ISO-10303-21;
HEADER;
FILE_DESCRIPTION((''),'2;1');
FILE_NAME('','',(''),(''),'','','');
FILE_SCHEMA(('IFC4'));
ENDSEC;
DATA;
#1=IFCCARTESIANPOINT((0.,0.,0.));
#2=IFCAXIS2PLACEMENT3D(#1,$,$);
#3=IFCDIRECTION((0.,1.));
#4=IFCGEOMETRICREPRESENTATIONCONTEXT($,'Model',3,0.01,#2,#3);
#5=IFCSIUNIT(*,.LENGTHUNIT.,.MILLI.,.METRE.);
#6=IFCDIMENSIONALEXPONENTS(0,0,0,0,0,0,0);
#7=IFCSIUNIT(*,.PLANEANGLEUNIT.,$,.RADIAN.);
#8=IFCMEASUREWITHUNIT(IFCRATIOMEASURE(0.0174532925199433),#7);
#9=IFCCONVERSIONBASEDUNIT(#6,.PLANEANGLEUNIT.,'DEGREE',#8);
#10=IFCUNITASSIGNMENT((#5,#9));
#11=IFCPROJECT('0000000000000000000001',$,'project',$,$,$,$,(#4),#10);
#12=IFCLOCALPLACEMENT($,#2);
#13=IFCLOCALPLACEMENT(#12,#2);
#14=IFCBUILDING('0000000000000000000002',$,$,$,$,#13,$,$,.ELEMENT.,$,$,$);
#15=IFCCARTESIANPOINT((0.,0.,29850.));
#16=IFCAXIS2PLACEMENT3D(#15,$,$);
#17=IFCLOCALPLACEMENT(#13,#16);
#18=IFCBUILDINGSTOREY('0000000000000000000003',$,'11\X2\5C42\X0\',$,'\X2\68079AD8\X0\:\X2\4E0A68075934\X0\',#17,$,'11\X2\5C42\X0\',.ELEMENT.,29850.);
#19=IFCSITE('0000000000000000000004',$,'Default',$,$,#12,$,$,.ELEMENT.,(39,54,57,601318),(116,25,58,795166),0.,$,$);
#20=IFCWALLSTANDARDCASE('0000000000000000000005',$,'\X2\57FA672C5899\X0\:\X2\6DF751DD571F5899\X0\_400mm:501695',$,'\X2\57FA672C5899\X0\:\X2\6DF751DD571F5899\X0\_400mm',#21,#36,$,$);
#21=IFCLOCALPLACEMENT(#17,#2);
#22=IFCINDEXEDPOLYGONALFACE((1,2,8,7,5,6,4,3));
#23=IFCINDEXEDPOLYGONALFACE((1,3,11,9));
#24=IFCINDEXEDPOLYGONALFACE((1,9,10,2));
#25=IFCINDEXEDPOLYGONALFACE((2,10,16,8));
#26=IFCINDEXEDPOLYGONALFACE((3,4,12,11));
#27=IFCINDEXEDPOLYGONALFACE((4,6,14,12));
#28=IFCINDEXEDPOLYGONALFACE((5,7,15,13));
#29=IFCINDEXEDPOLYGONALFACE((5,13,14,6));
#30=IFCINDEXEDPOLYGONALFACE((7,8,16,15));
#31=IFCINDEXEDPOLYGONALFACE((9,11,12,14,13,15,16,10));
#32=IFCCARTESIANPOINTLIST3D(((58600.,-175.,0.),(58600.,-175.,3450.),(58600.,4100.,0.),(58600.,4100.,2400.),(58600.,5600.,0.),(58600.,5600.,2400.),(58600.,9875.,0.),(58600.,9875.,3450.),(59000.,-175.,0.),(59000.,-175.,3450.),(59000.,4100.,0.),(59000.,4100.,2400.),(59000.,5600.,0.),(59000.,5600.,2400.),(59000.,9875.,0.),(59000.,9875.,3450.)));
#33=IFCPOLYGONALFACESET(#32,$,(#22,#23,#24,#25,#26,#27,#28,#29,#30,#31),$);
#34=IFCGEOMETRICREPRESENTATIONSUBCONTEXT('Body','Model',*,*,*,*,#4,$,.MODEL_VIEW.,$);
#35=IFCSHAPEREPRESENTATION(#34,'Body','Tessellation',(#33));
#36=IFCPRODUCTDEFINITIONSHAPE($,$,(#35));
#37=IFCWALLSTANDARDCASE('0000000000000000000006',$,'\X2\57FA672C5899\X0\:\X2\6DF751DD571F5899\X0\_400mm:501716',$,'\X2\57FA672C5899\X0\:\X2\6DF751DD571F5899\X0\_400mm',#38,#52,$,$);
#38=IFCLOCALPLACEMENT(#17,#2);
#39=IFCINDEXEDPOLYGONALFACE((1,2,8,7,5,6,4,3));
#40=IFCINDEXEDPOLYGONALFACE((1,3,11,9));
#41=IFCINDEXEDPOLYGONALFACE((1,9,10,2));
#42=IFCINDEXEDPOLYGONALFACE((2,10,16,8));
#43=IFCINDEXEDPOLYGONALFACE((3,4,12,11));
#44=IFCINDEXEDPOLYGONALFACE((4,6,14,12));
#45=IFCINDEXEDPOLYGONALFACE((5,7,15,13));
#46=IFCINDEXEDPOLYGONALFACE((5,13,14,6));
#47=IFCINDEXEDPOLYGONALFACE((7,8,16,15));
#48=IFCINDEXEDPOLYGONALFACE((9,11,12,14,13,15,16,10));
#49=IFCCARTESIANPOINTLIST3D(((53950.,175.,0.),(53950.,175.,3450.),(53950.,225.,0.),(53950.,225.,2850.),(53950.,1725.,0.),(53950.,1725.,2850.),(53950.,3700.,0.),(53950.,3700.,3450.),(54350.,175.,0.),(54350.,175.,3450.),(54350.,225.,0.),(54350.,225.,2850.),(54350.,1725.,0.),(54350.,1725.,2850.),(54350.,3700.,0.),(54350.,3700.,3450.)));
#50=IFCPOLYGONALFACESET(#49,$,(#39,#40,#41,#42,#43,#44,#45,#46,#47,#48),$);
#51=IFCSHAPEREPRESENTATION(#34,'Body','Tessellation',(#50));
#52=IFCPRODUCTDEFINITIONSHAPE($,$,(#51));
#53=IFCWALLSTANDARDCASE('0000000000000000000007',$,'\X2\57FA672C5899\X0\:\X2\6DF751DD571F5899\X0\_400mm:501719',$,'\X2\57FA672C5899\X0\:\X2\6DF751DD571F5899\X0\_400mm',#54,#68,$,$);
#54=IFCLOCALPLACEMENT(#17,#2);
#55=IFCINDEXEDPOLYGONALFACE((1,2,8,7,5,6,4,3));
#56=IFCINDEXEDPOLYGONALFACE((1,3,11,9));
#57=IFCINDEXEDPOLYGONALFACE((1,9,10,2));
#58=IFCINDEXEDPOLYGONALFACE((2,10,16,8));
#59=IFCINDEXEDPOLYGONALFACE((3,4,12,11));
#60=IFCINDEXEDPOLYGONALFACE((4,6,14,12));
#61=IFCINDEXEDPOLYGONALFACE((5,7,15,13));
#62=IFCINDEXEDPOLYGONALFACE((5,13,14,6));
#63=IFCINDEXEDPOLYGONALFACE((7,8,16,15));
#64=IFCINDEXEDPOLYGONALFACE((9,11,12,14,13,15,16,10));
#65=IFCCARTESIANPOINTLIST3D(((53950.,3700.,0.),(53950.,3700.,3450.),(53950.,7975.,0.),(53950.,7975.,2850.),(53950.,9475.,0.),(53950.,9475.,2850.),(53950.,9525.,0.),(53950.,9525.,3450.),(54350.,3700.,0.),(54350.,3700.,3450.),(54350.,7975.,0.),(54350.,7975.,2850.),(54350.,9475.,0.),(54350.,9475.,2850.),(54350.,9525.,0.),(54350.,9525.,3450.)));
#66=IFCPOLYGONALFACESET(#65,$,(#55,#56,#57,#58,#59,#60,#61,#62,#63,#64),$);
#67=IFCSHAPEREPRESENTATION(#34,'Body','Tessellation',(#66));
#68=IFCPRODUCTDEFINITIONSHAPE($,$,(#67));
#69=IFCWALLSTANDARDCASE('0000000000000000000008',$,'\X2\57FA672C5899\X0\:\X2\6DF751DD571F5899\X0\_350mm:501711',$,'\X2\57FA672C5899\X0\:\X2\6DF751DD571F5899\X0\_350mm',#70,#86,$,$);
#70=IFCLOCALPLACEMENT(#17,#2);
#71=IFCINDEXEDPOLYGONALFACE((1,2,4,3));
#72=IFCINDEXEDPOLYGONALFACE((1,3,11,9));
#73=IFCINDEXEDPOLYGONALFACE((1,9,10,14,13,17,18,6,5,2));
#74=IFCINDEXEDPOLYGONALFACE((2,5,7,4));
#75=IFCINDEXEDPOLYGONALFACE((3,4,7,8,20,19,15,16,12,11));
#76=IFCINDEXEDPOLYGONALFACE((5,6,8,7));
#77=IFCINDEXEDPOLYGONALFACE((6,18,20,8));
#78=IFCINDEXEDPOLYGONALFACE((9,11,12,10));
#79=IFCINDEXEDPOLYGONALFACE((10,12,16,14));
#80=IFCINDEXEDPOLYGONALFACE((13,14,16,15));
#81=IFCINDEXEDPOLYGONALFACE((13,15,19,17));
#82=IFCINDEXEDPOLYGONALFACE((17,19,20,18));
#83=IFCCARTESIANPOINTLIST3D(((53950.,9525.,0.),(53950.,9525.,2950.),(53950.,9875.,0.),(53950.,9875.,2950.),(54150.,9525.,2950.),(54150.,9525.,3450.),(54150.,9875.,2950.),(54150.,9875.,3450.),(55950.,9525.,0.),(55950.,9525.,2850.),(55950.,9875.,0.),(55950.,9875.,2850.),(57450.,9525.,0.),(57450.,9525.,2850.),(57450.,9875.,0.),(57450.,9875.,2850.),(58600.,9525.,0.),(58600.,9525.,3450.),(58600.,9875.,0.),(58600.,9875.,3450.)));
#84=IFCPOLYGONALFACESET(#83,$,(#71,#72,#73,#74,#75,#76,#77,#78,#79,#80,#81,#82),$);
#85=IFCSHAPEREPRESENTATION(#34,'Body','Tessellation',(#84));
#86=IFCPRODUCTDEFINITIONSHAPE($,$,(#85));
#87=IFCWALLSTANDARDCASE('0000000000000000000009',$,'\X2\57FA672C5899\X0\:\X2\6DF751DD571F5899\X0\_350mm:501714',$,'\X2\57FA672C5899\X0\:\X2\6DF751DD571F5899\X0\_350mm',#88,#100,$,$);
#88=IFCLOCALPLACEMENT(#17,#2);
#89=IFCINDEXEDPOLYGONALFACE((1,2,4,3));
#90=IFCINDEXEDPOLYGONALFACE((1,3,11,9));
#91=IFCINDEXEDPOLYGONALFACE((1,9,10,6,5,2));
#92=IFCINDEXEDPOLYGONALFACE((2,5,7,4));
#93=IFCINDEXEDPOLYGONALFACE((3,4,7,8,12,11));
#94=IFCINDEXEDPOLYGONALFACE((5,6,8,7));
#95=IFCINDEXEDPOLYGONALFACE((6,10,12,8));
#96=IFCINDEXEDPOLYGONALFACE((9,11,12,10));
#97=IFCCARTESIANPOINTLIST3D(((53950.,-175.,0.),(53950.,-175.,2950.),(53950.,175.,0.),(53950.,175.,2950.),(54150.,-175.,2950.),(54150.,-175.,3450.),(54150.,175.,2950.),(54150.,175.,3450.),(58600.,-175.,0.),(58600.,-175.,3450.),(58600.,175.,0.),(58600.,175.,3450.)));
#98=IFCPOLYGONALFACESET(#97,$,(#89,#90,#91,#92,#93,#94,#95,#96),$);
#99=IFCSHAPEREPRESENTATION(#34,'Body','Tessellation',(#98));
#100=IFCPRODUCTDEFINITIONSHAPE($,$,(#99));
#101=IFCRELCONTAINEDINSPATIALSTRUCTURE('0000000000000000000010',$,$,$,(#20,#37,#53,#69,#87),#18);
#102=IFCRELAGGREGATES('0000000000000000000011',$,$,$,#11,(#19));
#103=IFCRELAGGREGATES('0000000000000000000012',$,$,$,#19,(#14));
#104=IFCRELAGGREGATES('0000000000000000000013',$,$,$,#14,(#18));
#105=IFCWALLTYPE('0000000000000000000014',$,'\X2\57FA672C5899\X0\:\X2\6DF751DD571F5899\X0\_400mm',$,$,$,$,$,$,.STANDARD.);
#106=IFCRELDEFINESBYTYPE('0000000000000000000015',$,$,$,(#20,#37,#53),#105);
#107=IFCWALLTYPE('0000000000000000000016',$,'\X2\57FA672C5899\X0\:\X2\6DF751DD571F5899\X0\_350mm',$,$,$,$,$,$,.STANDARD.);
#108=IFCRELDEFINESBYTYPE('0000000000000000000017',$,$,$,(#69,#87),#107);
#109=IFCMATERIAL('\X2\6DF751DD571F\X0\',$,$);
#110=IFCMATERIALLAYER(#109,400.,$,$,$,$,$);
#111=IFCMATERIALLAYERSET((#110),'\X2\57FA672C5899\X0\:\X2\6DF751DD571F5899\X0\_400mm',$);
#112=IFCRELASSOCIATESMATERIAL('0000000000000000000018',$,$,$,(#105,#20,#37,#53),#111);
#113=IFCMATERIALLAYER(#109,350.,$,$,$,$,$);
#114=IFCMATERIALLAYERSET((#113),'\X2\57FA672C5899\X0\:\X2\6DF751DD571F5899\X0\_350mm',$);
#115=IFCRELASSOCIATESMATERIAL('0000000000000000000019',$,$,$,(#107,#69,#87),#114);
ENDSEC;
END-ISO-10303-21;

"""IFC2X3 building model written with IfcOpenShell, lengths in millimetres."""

from ifc_helpers import new_model, entity, si_unit, converted_unit, direction, frame, frame_2d, origin, origin_2d_with_axis, place, context, subcontext, project, spatial, polyline, rectangle, extrude, clip, bounded_halfspace, material, layer, layer_set, layer_usage, type_object, element, save


model = new_model("IFC2X3")

# Units and contexts
model_context = context("Model", 3, precision=0.01, world=origin(), true_north=direction((0.0, 1.0)))
body_context = subcontext(model_context, "Body", "Model", "MODEL_VIEW")
ifc_project = project(units=[si_unit("LENGTHUNIT", "METRE", prefix="MILLI"), converted_unit("PLANEANGLEUNIT", "DEGREE", entity("IfcRatioMeasure", 0.0174532925199433), si_unit("PLANEANGLEUNIT", "RADIAN"), dimensions=[0, 0, 0, 0, 0, 0, 0])], contexts=[model_context])

# Site, building, storey
site_placement = place(None, origin())
site = spatial("IfcSite", under=ifc_project, at=site_placement, Name="Default", CompositionType="ELEMENT", RefLatitude=(39, 54, 57, 601318), RefLongitude=(116, 25, 58, 795166), RefElevation=0.0)
building_placement = place(site_placement, origin())
building = spatial("IfcBuilding", under=site, at=building_placement, CompositionType="ELEMENT")
storey_placement = place(building_placement, frame((0.0, 0.0, 29850.0)))
storey = spatial("IfcBuildingStorey", under=building, at=storey_placement, Name="11层", ObjectType="标高:上标头", LongName="11层", CompositionType="ELEMENT", Elevation=29850.0)

# Walls, openings
ifc_material_1 = material(Name="混凝土")
ifc_layer_1 = layer(ifc_material_1, 400.0)
ifc_layer_set_1 = layer_set([ifc_layer_1], Name="基本墙:混凝土墙_400mm")
ifc_layer_usage_1 = layer_usage(ifc_layer_set_1, "AXIS2", "POSITIVE", -200.0)
wall_type_1 = type_object("IfcWallType", Name="基本墙:混凝土墙_400mm", PredefinedType="STANDARD", material=ifc_layer_set_1)
wall_1_placement = place(storey_placement, frame((58800.0, -175.0, 0.0), z_axis=(0.0, 0.0, 1.0), x_axis=(0.0, 1.0, 0.0)))
wall_1 = element("IfcWallStandardCase", 1, at=wall_1_placement, inside=storey, type_object=wall_type_1, material=ifc_layer_usage_1, Name="基本墙:混凝土墙_400mm:501695", ObjectType="基本墙:混凝土墙_400mm", context=body_context, shape_type="SweptSolid", body=[
    extrude(rectangle(XDim=10050.0, YDim=400.0, at=frame_2d((5025.0, 0.0), x_axis=(-1.0, 0.0))), origin(), (0.0, 0.0, 1.0), 3450.0),
])
opening_1_placement = place(wall_1_placement, origin())
element("IfcOpeningElement", 2, at=opening_1_placement, cuts=wall_1, ObjectType="Opening", context=body_context, shape_type="SweptSolid", body=[
    extrude(rectangle(XDim=2400.0, YDim=1500.0, at=frame_2d((0.0, 0.0), x_axis=(1.0, 0.0))), frame((5025.0, -200.0, 1200.0), z_axis=(0.0, 1.0, 0.0), x_axis=(0.0, 0.0, -1.0)), (0.0, 0.0, 1.0), 400.0),
])
ifc_layer_usage_2 = layer_usage(ifc_layer_set_1, "AXIS2", "POSITIVE", -200.0)
wall_2_placement = place(storey_placement, frame((54150.0, 175.0, 0.0), z_axis=(0.0, 0.0, 1.0), x_axis=(0.0, 1.0, 0.0)))
wall_2 = element("IfcWallStandardCase", 3, at=wall_2_placement, inside=storey, type_object=wall_type_1, material=ifc_layer_usage_2, Name="基本墙:混凝土墙_400mm:501716", ObjectType="基本墙:混凝土墙_400mm", context=body_context, shape_type="SweptSolid", body=[
    extrude(rectangle(XDim=3525.0, YDim=400.0, at=frame_2d((1762.5, 0.0), x_axis=(-1.0, 0.0))), origin(), (0.0, 0.0, 1.0), 3450.0),
])
opening_2_placement = place(wall_2_placement, origin())
element("IfcOpeningElement", 4, at=opening_2_placement, cuts=wall_2, ObjectType="Opening", context=body_context, shape_type="SweptSolid", body=[
    extrude(rectangle(XDim=2850.0, YDim=1500.0, at=origin_2d_with_axis()), frame((800.0, -200.0, 1425.0), z_axis=(0.0, 1.0, 0.0), x_axis=(0.0, 0.0, -1.0)), (0.0, 0.0, 1.0), 400.0),
])
ifc_layer_usage_3 = layer_usage(ifc_layer_set_1, "AXIS2", "POSITIVE", -200.0)
wall_3_placement = place(storey_placement, frame((54150.0, 3700.0, 0.0), z_axis=(0.0, 0.0, 1.0), x_axis=(0.0, 1.0, 0.0)))
wall_3 = element("IfcWallStandardCase", 5, at=wall_3_placement, inside=storey, type_object=wall_type_1, material=ifc_layer_usage_3, Name="基本墙:混凝土墙_400mm:501719", ObjectType="基本墙:混凝土墙_400mm", context=body_context, shape_type="SweptSolid", body=[
    extrude(rectangle(XDim=5825.0, YDim=400.0, at=frame_2d((2912.5, 0.0), x_axis=(-1.0, 0.0))), origin(), (0.0, 0.0, 1.0), 3450.0),
])
opening_3_placement = place(wall_3_placement, origin())
element("IfcOpeningElement", 6, at=opening_3_placement, cuts=wall_3, ObjectType="Opening", context=body_context, shape_type="SweptSolid", body=[
    extrude(rectangle(XDim=2850.0, YDim=1500.0, at=origin_2d_with_axis()), frame((5025.0, -200.0, 1425.0), z_axis=(0.0, 1.0, 0.0), x_axis=(0.0, 0.0, -1.0)), (0.0, 0.0, 1.0), 400.0),
])
ifc_layer_2 = layer(ifc_material_1, 350.0)
ifc_layer_set_2 = layer_set([ifc_layer_2], Name="基本墙:混凝土墙_350mm")
ifc_layer_usage_4 = layer_usage(ifc_layer_set_2, "AXIS2", "POSITIVE", -175.0)
wall_type_2 = type_object("IfcWallType", Name="基本墙:混凝土墙_350mm", PredefinedType="STANDARD", material=ifc_layer_set_2)
wall_4_placement = place(storey_placement, frame((53950.0, 9700.0, 0.0)))
wall_4 = element("IfcWallStandardCase", 7, at=wall_4_placement, inside=storey, type_object=wall_type_2, material=ifc_layer_usage_4, Name="基本墙:混凝土墙_350mm:501711", ObjectType="基本墙:混凝土墙_350mm", context=body_context, shape_type="Clipping", body=[
    clip(clip(extrude(rectangle(XDim=4650.0, YDim=350.0, at=frame_2d((2325.0, 0.0), x_axis=(-1.0, 0.0))), origin(), (0.0, 0.0, 1.0), 3450.0), bounded_halfspace(frame((200.0, 175.0, 2950.0), z_axis=(-1.0, 0.0, 0.0), x_axis=(0.0, 0.0, 1.0)), False, frame((200.0, 175.0, 2950.0), z_axis=(-1.0, 0.0, 0.0), x_axis=(0.0, 0.0, 1.0)), polyline([(0.0, 0.0), (0.0, -350.0), (500.0, -350.0), (500.0, 0.0), (0.0, 0.0)]))), bounded_halfspace(frame((200.0, -175.0, 2950.0), z_axis=(0.0, 0.0, -1.0), x_axis=(-1.0, 0.0, 0.0)), True, frame((200.0, -175.0, 2950.0), z_axis=(0.0, 0.0, -1.0), x_axis=(-1.0, 0.0, 0.0)), polyline([(0.0, 0.0), (200.0, 0.0), (200.0, 350.0), (0.0, 350.0), (0.0, 0.0)]))),
])
opening_4_placement = place(wall_4_placement, origin())
element("IfcOpeningElement", 8, at=opening_4_placement, cuts=wall_4, ObjectType="Opening", context=body_context, shape_type="SweptSolid", body=[
    extrude(rectangle(XDim=2850.0, YDim=1500.0, at=origin_2d_with_axis()), frame((2750.0, -175.0, 1425.0), z_axis=(0.0, 1.0, 0.0), x_axis=(0.0, 0.0, -1.0)), (0.0, 0.0, 1.0), 350.0),
])

# Wall
ifc_layer_usage_5 = layer_usage(ifc_layer_set_2, "AXIS2", "POSITIVE", -175.0)
wall_5_placement = place(storey_placement, frame((53950.0, 0.0, 0.0)))
element("IfcWallStandardCase", 9, at=wall_5_placement, inside=storey, type_object=wall_type_2, material=ifc_layer_usage_5, Name="基本墙:混凝土墙_350mm:501714", ObjectType="基本墙:混凝土墙_350mm", context=body_context, shape_type="Clipping", body=[
    clip(clip(extrude(rectangle(XDim=4650.0, YDim=350.0, at=frame_2d((2325.0, 0.0), x_axis=(-1.0, 0.0))), origin(), (0.0, 0.0, 1.0), 3450.0), bounded_halfspace(frame((200.0, 175.0, 2950.0), z_axis=(-1.0, 0.0, 0.0), x_axis=(0.0, 0.0, 1.0)), False, frame((200.0, 175.0, 2950.0), z_axis=(-1.0, 0.0, 0.0), x_axis=(0.0, 0.0, 1.0)), polyline([(0.0, 0.0), (0.0, -350.0), (500.0, -350.0), (500.0, 0.0), (0.0, 0.0)]))), bounded_halfspace(frame((200.0, -175.0, 2950.0), z_axis=(0.0, 0.0, -1.0), x_axis=(-1.0, 0.0, 0.0)), True, frame((200.0, -175.0, 2950.0), z_axis=(0.0, 0.0, -1.0), x_axis=(-1.0, 0.0, 0.0)), polyline([(0.0, 0.0), (200.0, 0.0), (200.0, 350.0), (0.0, 350.0), (0.0, 0.0)]))),
])

save(model, "model.ifc")
